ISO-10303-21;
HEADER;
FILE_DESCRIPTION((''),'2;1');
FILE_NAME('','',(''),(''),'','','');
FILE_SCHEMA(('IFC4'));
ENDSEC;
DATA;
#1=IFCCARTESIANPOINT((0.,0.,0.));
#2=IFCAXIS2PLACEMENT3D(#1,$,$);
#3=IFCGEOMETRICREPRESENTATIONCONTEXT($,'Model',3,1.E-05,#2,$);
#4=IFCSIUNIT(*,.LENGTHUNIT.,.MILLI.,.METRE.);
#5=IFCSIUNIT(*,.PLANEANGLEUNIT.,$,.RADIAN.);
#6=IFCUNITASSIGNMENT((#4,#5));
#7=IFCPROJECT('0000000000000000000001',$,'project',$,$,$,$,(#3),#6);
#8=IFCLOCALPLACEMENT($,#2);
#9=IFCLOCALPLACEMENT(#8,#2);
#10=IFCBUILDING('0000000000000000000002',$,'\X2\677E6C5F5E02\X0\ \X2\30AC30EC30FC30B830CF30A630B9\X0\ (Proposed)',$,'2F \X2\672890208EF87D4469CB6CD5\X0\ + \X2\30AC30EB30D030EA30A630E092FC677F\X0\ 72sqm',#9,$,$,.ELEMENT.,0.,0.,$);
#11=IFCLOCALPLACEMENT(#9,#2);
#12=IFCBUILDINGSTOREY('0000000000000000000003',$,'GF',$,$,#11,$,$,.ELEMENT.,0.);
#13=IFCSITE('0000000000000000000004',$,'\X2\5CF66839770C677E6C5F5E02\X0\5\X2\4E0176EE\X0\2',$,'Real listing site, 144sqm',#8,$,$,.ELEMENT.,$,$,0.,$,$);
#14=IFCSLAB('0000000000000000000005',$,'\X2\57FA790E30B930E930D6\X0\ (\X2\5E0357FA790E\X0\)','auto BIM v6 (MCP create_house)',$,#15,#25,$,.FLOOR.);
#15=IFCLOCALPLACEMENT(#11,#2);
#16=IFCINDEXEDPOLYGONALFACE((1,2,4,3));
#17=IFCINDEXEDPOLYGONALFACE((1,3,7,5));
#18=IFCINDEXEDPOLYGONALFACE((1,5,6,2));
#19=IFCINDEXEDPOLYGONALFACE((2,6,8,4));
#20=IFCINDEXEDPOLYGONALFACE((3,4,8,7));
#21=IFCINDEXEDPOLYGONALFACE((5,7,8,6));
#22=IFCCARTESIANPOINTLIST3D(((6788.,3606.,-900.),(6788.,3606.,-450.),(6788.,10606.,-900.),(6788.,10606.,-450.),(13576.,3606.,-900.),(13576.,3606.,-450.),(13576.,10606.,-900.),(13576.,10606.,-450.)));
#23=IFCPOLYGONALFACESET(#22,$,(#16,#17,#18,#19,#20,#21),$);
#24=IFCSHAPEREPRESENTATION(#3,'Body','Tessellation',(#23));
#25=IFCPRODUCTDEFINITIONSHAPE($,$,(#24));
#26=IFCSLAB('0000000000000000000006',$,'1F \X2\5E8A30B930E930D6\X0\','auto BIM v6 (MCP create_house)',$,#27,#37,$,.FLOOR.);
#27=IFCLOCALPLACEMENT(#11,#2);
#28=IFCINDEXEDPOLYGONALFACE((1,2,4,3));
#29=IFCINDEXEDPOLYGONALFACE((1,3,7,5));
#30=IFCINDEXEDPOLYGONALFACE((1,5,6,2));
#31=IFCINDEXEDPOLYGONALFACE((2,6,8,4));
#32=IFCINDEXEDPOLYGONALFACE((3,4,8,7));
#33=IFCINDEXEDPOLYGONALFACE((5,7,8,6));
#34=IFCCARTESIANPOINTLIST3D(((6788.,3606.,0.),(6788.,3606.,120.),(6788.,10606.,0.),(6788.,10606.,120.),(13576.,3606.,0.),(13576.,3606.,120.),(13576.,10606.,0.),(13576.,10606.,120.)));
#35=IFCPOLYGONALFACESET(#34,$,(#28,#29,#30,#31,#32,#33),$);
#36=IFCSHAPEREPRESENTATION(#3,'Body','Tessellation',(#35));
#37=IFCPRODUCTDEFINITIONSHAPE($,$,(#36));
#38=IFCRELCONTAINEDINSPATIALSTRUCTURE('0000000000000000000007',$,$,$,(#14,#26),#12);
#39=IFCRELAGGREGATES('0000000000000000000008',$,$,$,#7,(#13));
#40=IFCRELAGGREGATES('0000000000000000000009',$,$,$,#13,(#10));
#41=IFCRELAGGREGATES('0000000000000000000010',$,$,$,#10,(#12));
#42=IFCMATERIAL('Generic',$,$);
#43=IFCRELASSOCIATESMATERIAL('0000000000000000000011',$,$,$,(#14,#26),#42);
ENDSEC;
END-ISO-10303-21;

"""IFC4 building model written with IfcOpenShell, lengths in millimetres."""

from ifc_helpers import new_model, si_unit, frame, frame_2d, origin, place, context, project, spatial, rectangle, extrude, material, element, save


model = new_model("IFC4")

# Units and contexts
model_context = context("Model", 3, precision=1e-05, world=origin())
ifc_project = project(units=[si_unit("LENGTHUNIT", "METRE", prefix="MILLI"), si_unit("PLANEANGLEUNIT", "RADIAN")], contexts=[model_context])

# Site, building, storey
site_placement = place(None, origin())
site = spatial("IfcSite", under=ifc_project, at=site_placement, Name="島根県松江市5丁目2", ObjectType="Real listing site, 144sqm", CompositionType="ELEMENT", RefElevation=0.0)
building_placement = place(site_placement, origin())
building = spatial("IfcBuilding", under=site, at=building_placement, Name="松江市 ガレージハウス (Proposed)", ObjectType="2F 木造軸組構法 + ガルバリウム鋼板 72sqm", CompositionType="ELEMENT", ElevationOfRefHeight=0.0, ElevationOfTerrain=0.0)
storey_placement = place(building_placement, origin())
storey = spatial("IfcBuildingStorey", under=building, at=storey_placement, Name="GF", CompositionType="ELEMENT", Elevation=0.0)

# Slabs
ifc_material = material(Name="Generic")
slab_1_placement = place(storey_placement, frame((3394.0, 1803.0, -450.0)))
element("IfcSlab", 1, at=slab_1_placement, inside=storey, material=ifc_material, Name="基礎スラブ (布基礎)", Description="auto BIM v6 (MCP create_house)", PredefinedType="FLOOR", context=model_context, shape_type="SweptSolid", body=[
    extrude(rectangle(XDim=6788.0, YDim=7000.0, at=frame_2d((3394.0, 3500.0))), frame((3394.0, 1803.0, -450.0)), (0.0, 0.0, 1.0), 450.0),
])
slab_2_placement = place(storey_placement, frame((3394.0, 1803.0, 0.0)))
element("IfcSlab", 2, at=slab_2_placement, inside=storey, material=ifc_material, Name="1F 床スラブ", Description="auto BIM v6 (MCP create_house)", PredefinedType="FLOOR", context=model_context, shape_type="SweptSolid", body=[
    extrude(rectangle(XDim=6788.0, YDim=7000.0, at=frame_2d((3394.0, 3500.0))), frame((3394.0, 1803.0, 0.0)), (0.0, 0.0, 1.0), 120.0),
])

save(model, "model.ifc")
